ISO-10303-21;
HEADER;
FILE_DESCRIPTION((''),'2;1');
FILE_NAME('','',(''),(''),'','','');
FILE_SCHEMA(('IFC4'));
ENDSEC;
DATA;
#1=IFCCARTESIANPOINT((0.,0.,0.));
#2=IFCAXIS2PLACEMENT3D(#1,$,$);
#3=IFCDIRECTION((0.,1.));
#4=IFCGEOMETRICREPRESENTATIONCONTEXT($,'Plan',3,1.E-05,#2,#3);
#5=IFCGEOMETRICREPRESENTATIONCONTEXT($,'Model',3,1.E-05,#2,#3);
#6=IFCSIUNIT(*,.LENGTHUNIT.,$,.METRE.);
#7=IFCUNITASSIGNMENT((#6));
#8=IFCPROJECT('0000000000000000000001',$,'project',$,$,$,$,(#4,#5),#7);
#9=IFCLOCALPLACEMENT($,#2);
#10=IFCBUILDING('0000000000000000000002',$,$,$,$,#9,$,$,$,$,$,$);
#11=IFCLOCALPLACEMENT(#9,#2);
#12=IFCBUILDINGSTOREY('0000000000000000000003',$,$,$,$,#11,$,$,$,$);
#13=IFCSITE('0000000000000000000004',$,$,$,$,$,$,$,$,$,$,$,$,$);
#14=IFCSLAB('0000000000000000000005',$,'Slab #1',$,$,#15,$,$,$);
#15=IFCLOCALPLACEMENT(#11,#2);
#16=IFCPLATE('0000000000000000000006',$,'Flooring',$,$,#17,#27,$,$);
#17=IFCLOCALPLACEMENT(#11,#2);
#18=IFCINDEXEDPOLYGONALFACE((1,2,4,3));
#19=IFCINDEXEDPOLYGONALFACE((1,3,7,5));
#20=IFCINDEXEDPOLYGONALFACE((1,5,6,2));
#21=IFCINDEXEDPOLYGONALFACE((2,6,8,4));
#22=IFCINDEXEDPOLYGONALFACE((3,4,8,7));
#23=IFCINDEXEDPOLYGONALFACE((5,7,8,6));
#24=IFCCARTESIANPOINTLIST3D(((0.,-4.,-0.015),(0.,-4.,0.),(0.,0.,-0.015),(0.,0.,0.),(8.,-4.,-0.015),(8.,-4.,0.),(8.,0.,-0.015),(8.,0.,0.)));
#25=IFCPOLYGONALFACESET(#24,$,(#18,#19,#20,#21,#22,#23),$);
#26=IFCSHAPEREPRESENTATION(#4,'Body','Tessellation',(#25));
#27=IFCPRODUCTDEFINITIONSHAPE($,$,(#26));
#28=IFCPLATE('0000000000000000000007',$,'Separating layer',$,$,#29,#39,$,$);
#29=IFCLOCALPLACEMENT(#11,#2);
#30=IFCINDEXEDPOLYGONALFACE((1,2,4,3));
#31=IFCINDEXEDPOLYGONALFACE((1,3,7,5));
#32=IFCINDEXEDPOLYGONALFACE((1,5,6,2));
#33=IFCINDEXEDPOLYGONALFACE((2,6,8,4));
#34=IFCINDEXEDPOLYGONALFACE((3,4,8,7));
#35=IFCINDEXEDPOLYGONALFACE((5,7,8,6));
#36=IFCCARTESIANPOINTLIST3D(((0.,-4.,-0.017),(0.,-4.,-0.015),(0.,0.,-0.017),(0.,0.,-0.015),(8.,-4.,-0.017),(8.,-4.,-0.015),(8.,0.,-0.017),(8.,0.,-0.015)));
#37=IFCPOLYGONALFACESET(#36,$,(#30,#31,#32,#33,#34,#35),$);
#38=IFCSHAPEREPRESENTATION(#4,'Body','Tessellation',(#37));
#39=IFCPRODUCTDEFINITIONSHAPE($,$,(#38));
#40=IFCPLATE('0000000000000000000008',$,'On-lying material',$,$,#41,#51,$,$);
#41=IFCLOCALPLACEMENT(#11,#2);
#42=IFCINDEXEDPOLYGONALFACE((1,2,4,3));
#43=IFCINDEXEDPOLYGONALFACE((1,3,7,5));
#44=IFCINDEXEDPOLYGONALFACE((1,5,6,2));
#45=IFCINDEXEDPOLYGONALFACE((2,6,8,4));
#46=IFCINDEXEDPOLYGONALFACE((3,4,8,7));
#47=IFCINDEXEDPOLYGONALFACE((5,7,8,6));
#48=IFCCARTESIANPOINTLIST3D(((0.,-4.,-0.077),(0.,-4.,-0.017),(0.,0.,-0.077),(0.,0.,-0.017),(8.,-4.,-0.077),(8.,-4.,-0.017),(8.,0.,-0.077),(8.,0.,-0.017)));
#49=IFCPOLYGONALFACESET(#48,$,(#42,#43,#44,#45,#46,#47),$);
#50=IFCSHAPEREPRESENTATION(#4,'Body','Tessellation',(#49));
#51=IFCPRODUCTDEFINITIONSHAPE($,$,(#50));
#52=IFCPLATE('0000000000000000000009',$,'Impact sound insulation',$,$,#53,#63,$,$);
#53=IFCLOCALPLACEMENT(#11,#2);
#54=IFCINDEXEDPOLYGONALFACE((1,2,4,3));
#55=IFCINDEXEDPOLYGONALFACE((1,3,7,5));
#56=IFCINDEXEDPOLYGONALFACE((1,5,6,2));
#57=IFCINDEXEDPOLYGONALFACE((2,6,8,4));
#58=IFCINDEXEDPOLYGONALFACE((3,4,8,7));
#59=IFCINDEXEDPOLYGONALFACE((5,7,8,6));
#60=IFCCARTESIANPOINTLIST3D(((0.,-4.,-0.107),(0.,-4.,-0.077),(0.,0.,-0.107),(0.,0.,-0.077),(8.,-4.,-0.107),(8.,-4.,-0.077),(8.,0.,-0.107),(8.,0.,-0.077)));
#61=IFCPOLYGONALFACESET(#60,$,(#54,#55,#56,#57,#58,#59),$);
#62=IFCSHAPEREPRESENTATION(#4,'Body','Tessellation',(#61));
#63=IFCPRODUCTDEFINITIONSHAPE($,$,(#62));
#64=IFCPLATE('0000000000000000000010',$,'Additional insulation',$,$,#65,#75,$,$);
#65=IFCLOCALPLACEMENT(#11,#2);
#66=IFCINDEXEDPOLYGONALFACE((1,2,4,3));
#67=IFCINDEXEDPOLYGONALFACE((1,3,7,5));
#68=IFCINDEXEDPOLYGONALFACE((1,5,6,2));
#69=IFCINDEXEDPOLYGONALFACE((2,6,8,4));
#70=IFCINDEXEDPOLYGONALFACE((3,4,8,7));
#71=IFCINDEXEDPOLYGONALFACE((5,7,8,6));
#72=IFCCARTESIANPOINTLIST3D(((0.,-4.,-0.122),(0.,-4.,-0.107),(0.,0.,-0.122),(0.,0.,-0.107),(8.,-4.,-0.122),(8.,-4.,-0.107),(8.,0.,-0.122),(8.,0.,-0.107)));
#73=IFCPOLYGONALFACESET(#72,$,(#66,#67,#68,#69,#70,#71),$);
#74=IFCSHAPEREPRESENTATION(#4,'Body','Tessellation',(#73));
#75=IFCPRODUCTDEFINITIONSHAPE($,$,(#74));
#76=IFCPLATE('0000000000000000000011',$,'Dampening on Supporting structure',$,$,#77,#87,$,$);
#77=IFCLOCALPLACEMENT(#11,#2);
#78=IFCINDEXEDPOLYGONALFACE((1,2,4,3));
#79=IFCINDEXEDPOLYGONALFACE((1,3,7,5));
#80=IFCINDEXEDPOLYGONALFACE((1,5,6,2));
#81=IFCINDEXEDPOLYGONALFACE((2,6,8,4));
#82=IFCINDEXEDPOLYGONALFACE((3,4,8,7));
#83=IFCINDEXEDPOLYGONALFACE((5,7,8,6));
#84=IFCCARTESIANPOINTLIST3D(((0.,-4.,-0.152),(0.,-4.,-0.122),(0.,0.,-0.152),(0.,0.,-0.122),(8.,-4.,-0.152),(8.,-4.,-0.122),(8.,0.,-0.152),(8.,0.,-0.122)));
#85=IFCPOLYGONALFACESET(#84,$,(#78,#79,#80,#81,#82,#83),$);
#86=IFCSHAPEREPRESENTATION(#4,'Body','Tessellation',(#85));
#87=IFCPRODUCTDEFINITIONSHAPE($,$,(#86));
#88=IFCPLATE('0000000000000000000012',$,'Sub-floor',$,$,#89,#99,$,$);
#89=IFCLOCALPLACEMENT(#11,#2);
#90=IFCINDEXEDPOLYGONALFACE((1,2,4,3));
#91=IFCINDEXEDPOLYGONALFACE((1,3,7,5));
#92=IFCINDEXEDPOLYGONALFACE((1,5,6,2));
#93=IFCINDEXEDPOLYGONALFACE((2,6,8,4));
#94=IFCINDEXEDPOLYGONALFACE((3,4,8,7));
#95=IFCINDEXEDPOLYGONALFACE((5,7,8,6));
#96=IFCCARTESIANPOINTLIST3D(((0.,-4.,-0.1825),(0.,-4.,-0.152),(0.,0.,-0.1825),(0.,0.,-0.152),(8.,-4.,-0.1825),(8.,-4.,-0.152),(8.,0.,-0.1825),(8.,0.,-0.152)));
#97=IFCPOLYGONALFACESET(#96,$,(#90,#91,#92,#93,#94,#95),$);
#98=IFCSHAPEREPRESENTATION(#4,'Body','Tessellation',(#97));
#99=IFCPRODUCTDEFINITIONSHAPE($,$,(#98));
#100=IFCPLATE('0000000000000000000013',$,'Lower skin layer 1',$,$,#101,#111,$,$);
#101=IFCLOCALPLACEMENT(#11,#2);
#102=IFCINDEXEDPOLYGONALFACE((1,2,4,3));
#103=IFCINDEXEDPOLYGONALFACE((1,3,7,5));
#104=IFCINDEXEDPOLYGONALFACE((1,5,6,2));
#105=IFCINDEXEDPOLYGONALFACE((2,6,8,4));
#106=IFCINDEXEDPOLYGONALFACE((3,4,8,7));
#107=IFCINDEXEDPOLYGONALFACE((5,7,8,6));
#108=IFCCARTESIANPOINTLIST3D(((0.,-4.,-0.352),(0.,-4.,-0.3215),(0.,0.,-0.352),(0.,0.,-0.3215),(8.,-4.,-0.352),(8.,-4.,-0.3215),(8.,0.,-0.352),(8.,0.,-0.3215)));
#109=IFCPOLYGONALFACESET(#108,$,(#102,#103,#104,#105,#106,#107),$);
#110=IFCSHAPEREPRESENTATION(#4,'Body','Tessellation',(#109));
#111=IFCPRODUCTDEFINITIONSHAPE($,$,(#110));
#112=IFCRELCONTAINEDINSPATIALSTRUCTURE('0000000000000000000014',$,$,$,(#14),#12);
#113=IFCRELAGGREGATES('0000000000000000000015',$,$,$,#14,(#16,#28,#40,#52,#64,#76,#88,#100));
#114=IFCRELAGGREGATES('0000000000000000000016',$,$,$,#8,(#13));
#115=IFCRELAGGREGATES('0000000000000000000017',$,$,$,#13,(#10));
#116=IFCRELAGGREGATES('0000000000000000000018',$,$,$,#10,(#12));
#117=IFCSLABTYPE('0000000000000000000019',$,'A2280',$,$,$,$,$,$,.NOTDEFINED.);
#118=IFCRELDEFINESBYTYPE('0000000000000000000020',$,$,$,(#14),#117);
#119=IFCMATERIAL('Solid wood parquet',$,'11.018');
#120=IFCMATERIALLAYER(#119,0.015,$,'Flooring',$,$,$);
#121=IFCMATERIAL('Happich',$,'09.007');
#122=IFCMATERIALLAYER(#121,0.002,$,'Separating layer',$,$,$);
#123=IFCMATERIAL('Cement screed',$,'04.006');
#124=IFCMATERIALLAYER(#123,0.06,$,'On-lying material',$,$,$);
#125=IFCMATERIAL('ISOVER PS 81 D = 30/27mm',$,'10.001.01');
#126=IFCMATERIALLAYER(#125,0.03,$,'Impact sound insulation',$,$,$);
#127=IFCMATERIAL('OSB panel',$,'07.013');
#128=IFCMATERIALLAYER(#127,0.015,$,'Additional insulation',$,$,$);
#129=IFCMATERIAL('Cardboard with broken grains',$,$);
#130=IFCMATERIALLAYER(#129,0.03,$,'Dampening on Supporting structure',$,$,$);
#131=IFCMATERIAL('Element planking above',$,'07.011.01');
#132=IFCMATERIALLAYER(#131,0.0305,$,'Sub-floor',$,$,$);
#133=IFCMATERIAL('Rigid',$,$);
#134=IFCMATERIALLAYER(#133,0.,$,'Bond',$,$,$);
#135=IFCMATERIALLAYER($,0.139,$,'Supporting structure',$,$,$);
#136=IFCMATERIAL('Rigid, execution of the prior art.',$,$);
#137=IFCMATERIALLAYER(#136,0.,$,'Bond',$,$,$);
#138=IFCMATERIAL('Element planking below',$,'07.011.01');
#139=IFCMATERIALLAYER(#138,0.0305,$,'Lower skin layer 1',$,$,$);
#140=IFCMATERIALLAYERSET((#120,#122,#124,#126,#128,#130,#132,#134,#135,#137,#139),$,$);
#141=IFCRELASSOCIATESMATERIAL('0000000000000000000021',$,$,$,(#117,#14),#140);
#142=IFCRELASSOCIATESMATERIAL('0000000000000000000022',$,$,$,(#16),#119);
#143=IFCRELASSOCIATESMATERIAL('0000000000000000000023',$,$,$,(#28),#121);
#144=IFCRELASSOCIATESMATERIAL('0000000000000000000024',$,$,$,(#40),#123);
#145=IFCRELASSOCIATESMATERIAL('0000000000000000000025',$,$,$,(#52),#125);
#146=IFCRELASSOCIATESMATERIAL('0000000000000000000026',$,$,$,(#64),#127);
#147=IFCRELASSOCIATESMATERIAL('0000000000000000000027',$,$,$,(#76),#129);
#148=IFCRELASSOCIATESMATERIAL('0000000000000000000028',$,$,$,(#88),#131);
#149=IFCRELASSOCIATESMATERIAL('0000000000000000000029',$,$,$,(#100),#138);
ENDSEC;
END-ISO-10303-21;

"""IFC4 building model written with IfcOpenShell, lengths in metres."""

from ifc_helpers import new_model, si_unit, direction, frame, frame_2d, origin, origin_with_axes, place, context, project, spatial, rectangle, extrude, material, layer, layer_set, type_object, element, aggregate, save


model = new_model("IFC4")

# Units and contexts
plan_context = context("Plan", 3, precision=1e-05, world=origin(), true_north=direction((0.0, 1.0)))
model_context = context("Model", 3, precision=1e-05, world=origin(), true_north=direction((0.0, 1.0)))
ifc_project = project(units=[si_unit("LENGTHUNIT", "METRE")], contexts=[plan_context, model_context])

# Site, building, storey
site = spatial("IfcSite", under=ifc_project)
building_placement = place(None, origin())
building = spatial("IfcBuilding", under=site, at=building_placement)
storey_placement = place(building_placement, origin())
storey = spatial("IfcBuildingStorey", under=building, at=storey_placement)

# Slab, plates
ifc_material_1 = material(Name="Solid wood parquet", Category="11.018")
ifc_layer_1 = layer(ifc_material_1, 0.015, Name="Flooring")
ifc_material_2 = material(Name="Happich", Category="09.007")
ifc_layer_2 = layer(ifc_material_2, 0.002, Name="Separating layer")
ifc_material_3 = material(Name="Cement screed", Category="04.006")
ifc_layer_3 = layer(ifc_material_3, 0.06, Name="On-lying material")
ifc_material_4 = material(Name="ISOVER PS 81 D = 30/27mm", Category="10.001.01")
ifc_layer_4 = layer(ifc_material_4, 0.03, Name="Impact sound insulation")
ifc_material_5 = material(Name="OSB panel", Category="07.013")
ifc_layer_5 = layer(ifc_material_5, 0.015, Name="Additional insulation")
ifc_material_6 = material(Name="Cardboard with broken grains")
ifc_layer_6 = layer(ifc_material_6, 0.03, Name="Dampening on Supporting structure")
ifc_material_7 = material(Name="Element planking above", Category="07.011.01")
ifc_layer_7 = layer(ifc_material_7, 0.0305, Name="Sub-floor")
ifc_material_8 = material(Name="Rigid")
ifc_layer_8 = layer(ifc_material_8, 0.0, Name="Bond")
ifc_layer_9 = layer(None, 0.139, Name="Supporting structure")
ifc_material_9 = material(Name="Rigid, execution of the prior art.")
ifc_layer_10 = layer(ifc_material_9, 0.0, Name="Bond")
ifc_material_10 = material(Name="Element planking below", Category="07.011.01")
ifc_layer_11 = layer(ifc_material_10, 0.0305, Name="Lower skin layer 1")
ifc_layer_set = layer_set([ifc_layer_1, ifc_layer_2, ifc_layer_3, ifc_layer_4, ifc_layer_5, ifc_layer_6, ifc_layer_7, ifc_layer_8, ifc_layer_9, ifc_layer_10, ifc_layer_11])
slab_type = type_object("IfcSlabType", Name="A2280", PredefinedType="NOTDEFINED", material=ifc_layer_set)
slab_placement = place(None, frame((0.0, 0.0, 0.0), z_axis=(0.0, 0.0, -1.0), x_axis=(1.0, 0.0, 0.0)))
slab = element("IfcSlab", 1, at=slab_placement, inside=storey, type_object=slab_type, material=ifc_layer_set, Name="Slab #1")
plate_1_placement = place(slab_placement, origin())
plate_1 = element("IfcPlate", 2, at=plate_1_placement, material=ifc_material_1, Name="Flooring", context=plan_context, shape_type="SweptSolid", body=[
    extrude(rectangle(XDim=8.0, YDim=4.0, at=frame_2d((4.0, 2.0), x_axis=(1.0, 0.0))), origin_with_axes(), (0.0, 0.0, 1.0), 0.015),
])
plate_2_placement = place(slab_placement, origin())
plate_2 = element("IfcPlate", 3, at=plate_2_placement, material=ifc_material_2, Name="Separating layer", context=plan_context, shape_type="SweptSolid", body=[
    extrude(rectangle(XDim=8.0, YDim=4.0, at=frame_2d((4.0, 2.0), x_axis=(1.0, 0.0))), frame((0.0, 0.0, 0.015), z_axis=(0.0, 0.0, 1.0), x_axis=(1.0, 0.0, 0.0)), (0.0, 0.0, 1.0), 0.002),
])
plate_3_placement = place(slab_placement, origin())
plate_3 = element("IfcPlate", 4, at=plate_3_placement, material=ifc_material_3, Name="On-lying material", context=plan_context, shape_type="SweptSolid", body=[
    extrude(rectangle(XDim=8.0, YDim=4.0, at=frame_2d((4.0, 2.0), x_axis=(1.0, 0.0))), frame((0.0, 0.0, 0.017), z_axis=(0.0, 0.0, 1.0), x_axis=(1.0, 0.0, 0.0)), (0.0, 0.0, 1.0), 0.06),
])
plate_4_placement = place(slab_placement, origin())
plate_4 = element("IfcPlate", 5, at=plate_4_placement, material=ifc_material_4, Name="Impact sound insulation", context=plan_context, shape_type="SweptSolid", body=[
    extrude(rectangle(XDim=8.0, YDim=4.0, at=frame_2d((4.0, 2.0), x_axis=(1.0, 0.0))), frame((0.0, 0.0, 0.077), z_axis=(0.0, 0.0, 1.0), x_axis=(1.0, 0.0, 0.0)), (0.0, 0.0, 1.0), 0.03),
])
plate_5_placement = place(slab_placement, origin())
plate_5 = element("IfcPlate", 6, at=plate_5_placement, material=ifc_material_5, Name="Additional insulation", context=plan_context, shape_type="SweptSolid", body=[
    extrude(rectangle(XDim=8.0, YDim=4.0, at=frame_2d((4.0, 2.0), x_axis=(1.0, 0.0))), frame((0.0, 0.0, 0.107), z_axis=(0.0, 0.0, 1.0), x_axis=(1.0, 0.0, 0.0)), (0.0, 0.0, 1.0), 0.015),
])
plate_6_placement = place(slab_placement, origin())
plate_6 = element("IfcPlate", 7, at=plate_6_placement, material=ifc_material_6, Name="Dampening on Supporting structure", context=plan_context, shape_type="SweptSolid", body=[
    extrude(rectangle(XDim=8.0, YDim=4.0, at=frame_2d((4.0, 2.0), x_axis=(1.0, 0.0))), frame((0.0, 0.0, 0.122), z_axis=(0.0, 0.0, 1.0), x_axis=(1.0, 0.0, 0.0)), (0.0, 0.0, 1.0), 0.03),
])
plate_7_placement = place(slab_placement, origin())
plate_7 = element("IfcPlate", 8, at=plate_7_placement, material=ifc_material_7, Name="Sub-floor", context=plan_context, shape_type="SweptSolid", body=[
    extrude(rectangle(XDim=8.0, YDim=4.0, at=frame_2d((4.0, 2.0), x_axis=(1.0, 0.0))), frame((0.0, 0.0, 0.152), z_axis=(0.0, 0.0, 1.0), x_axis=(1.0, 0.0, 0.0)), (0.0, 0.0, 1.0), 0.0305),
])
plate_8_placement = place(slab_placement, origin())
plate_8 = element("IfcPlate", 9, at=plate_8_placement, material=ifc_material_10, Name="Lower skin layer 1", context=plan_context, shape_type="SweptSolid", body=[
    extrude(rectangle(XDim=8.0, YDim=4.0, at=frame_2d((4.0, 2.0), x_axis=(1.0, 0.0))), frame((0.0, 0.0, 0.3215), z_axis=(0.0, 0.0, 1.0), x_axis=(1.0, 0.0, 0.0)), (0.0, 0.0, 1.0), 0.0305),
])
aggregate(slab, [plate_1, plate_2, plate_3, plate_4, plate_5, plate_6, plate_7, plate_8])

save(model, "model.ifc")
